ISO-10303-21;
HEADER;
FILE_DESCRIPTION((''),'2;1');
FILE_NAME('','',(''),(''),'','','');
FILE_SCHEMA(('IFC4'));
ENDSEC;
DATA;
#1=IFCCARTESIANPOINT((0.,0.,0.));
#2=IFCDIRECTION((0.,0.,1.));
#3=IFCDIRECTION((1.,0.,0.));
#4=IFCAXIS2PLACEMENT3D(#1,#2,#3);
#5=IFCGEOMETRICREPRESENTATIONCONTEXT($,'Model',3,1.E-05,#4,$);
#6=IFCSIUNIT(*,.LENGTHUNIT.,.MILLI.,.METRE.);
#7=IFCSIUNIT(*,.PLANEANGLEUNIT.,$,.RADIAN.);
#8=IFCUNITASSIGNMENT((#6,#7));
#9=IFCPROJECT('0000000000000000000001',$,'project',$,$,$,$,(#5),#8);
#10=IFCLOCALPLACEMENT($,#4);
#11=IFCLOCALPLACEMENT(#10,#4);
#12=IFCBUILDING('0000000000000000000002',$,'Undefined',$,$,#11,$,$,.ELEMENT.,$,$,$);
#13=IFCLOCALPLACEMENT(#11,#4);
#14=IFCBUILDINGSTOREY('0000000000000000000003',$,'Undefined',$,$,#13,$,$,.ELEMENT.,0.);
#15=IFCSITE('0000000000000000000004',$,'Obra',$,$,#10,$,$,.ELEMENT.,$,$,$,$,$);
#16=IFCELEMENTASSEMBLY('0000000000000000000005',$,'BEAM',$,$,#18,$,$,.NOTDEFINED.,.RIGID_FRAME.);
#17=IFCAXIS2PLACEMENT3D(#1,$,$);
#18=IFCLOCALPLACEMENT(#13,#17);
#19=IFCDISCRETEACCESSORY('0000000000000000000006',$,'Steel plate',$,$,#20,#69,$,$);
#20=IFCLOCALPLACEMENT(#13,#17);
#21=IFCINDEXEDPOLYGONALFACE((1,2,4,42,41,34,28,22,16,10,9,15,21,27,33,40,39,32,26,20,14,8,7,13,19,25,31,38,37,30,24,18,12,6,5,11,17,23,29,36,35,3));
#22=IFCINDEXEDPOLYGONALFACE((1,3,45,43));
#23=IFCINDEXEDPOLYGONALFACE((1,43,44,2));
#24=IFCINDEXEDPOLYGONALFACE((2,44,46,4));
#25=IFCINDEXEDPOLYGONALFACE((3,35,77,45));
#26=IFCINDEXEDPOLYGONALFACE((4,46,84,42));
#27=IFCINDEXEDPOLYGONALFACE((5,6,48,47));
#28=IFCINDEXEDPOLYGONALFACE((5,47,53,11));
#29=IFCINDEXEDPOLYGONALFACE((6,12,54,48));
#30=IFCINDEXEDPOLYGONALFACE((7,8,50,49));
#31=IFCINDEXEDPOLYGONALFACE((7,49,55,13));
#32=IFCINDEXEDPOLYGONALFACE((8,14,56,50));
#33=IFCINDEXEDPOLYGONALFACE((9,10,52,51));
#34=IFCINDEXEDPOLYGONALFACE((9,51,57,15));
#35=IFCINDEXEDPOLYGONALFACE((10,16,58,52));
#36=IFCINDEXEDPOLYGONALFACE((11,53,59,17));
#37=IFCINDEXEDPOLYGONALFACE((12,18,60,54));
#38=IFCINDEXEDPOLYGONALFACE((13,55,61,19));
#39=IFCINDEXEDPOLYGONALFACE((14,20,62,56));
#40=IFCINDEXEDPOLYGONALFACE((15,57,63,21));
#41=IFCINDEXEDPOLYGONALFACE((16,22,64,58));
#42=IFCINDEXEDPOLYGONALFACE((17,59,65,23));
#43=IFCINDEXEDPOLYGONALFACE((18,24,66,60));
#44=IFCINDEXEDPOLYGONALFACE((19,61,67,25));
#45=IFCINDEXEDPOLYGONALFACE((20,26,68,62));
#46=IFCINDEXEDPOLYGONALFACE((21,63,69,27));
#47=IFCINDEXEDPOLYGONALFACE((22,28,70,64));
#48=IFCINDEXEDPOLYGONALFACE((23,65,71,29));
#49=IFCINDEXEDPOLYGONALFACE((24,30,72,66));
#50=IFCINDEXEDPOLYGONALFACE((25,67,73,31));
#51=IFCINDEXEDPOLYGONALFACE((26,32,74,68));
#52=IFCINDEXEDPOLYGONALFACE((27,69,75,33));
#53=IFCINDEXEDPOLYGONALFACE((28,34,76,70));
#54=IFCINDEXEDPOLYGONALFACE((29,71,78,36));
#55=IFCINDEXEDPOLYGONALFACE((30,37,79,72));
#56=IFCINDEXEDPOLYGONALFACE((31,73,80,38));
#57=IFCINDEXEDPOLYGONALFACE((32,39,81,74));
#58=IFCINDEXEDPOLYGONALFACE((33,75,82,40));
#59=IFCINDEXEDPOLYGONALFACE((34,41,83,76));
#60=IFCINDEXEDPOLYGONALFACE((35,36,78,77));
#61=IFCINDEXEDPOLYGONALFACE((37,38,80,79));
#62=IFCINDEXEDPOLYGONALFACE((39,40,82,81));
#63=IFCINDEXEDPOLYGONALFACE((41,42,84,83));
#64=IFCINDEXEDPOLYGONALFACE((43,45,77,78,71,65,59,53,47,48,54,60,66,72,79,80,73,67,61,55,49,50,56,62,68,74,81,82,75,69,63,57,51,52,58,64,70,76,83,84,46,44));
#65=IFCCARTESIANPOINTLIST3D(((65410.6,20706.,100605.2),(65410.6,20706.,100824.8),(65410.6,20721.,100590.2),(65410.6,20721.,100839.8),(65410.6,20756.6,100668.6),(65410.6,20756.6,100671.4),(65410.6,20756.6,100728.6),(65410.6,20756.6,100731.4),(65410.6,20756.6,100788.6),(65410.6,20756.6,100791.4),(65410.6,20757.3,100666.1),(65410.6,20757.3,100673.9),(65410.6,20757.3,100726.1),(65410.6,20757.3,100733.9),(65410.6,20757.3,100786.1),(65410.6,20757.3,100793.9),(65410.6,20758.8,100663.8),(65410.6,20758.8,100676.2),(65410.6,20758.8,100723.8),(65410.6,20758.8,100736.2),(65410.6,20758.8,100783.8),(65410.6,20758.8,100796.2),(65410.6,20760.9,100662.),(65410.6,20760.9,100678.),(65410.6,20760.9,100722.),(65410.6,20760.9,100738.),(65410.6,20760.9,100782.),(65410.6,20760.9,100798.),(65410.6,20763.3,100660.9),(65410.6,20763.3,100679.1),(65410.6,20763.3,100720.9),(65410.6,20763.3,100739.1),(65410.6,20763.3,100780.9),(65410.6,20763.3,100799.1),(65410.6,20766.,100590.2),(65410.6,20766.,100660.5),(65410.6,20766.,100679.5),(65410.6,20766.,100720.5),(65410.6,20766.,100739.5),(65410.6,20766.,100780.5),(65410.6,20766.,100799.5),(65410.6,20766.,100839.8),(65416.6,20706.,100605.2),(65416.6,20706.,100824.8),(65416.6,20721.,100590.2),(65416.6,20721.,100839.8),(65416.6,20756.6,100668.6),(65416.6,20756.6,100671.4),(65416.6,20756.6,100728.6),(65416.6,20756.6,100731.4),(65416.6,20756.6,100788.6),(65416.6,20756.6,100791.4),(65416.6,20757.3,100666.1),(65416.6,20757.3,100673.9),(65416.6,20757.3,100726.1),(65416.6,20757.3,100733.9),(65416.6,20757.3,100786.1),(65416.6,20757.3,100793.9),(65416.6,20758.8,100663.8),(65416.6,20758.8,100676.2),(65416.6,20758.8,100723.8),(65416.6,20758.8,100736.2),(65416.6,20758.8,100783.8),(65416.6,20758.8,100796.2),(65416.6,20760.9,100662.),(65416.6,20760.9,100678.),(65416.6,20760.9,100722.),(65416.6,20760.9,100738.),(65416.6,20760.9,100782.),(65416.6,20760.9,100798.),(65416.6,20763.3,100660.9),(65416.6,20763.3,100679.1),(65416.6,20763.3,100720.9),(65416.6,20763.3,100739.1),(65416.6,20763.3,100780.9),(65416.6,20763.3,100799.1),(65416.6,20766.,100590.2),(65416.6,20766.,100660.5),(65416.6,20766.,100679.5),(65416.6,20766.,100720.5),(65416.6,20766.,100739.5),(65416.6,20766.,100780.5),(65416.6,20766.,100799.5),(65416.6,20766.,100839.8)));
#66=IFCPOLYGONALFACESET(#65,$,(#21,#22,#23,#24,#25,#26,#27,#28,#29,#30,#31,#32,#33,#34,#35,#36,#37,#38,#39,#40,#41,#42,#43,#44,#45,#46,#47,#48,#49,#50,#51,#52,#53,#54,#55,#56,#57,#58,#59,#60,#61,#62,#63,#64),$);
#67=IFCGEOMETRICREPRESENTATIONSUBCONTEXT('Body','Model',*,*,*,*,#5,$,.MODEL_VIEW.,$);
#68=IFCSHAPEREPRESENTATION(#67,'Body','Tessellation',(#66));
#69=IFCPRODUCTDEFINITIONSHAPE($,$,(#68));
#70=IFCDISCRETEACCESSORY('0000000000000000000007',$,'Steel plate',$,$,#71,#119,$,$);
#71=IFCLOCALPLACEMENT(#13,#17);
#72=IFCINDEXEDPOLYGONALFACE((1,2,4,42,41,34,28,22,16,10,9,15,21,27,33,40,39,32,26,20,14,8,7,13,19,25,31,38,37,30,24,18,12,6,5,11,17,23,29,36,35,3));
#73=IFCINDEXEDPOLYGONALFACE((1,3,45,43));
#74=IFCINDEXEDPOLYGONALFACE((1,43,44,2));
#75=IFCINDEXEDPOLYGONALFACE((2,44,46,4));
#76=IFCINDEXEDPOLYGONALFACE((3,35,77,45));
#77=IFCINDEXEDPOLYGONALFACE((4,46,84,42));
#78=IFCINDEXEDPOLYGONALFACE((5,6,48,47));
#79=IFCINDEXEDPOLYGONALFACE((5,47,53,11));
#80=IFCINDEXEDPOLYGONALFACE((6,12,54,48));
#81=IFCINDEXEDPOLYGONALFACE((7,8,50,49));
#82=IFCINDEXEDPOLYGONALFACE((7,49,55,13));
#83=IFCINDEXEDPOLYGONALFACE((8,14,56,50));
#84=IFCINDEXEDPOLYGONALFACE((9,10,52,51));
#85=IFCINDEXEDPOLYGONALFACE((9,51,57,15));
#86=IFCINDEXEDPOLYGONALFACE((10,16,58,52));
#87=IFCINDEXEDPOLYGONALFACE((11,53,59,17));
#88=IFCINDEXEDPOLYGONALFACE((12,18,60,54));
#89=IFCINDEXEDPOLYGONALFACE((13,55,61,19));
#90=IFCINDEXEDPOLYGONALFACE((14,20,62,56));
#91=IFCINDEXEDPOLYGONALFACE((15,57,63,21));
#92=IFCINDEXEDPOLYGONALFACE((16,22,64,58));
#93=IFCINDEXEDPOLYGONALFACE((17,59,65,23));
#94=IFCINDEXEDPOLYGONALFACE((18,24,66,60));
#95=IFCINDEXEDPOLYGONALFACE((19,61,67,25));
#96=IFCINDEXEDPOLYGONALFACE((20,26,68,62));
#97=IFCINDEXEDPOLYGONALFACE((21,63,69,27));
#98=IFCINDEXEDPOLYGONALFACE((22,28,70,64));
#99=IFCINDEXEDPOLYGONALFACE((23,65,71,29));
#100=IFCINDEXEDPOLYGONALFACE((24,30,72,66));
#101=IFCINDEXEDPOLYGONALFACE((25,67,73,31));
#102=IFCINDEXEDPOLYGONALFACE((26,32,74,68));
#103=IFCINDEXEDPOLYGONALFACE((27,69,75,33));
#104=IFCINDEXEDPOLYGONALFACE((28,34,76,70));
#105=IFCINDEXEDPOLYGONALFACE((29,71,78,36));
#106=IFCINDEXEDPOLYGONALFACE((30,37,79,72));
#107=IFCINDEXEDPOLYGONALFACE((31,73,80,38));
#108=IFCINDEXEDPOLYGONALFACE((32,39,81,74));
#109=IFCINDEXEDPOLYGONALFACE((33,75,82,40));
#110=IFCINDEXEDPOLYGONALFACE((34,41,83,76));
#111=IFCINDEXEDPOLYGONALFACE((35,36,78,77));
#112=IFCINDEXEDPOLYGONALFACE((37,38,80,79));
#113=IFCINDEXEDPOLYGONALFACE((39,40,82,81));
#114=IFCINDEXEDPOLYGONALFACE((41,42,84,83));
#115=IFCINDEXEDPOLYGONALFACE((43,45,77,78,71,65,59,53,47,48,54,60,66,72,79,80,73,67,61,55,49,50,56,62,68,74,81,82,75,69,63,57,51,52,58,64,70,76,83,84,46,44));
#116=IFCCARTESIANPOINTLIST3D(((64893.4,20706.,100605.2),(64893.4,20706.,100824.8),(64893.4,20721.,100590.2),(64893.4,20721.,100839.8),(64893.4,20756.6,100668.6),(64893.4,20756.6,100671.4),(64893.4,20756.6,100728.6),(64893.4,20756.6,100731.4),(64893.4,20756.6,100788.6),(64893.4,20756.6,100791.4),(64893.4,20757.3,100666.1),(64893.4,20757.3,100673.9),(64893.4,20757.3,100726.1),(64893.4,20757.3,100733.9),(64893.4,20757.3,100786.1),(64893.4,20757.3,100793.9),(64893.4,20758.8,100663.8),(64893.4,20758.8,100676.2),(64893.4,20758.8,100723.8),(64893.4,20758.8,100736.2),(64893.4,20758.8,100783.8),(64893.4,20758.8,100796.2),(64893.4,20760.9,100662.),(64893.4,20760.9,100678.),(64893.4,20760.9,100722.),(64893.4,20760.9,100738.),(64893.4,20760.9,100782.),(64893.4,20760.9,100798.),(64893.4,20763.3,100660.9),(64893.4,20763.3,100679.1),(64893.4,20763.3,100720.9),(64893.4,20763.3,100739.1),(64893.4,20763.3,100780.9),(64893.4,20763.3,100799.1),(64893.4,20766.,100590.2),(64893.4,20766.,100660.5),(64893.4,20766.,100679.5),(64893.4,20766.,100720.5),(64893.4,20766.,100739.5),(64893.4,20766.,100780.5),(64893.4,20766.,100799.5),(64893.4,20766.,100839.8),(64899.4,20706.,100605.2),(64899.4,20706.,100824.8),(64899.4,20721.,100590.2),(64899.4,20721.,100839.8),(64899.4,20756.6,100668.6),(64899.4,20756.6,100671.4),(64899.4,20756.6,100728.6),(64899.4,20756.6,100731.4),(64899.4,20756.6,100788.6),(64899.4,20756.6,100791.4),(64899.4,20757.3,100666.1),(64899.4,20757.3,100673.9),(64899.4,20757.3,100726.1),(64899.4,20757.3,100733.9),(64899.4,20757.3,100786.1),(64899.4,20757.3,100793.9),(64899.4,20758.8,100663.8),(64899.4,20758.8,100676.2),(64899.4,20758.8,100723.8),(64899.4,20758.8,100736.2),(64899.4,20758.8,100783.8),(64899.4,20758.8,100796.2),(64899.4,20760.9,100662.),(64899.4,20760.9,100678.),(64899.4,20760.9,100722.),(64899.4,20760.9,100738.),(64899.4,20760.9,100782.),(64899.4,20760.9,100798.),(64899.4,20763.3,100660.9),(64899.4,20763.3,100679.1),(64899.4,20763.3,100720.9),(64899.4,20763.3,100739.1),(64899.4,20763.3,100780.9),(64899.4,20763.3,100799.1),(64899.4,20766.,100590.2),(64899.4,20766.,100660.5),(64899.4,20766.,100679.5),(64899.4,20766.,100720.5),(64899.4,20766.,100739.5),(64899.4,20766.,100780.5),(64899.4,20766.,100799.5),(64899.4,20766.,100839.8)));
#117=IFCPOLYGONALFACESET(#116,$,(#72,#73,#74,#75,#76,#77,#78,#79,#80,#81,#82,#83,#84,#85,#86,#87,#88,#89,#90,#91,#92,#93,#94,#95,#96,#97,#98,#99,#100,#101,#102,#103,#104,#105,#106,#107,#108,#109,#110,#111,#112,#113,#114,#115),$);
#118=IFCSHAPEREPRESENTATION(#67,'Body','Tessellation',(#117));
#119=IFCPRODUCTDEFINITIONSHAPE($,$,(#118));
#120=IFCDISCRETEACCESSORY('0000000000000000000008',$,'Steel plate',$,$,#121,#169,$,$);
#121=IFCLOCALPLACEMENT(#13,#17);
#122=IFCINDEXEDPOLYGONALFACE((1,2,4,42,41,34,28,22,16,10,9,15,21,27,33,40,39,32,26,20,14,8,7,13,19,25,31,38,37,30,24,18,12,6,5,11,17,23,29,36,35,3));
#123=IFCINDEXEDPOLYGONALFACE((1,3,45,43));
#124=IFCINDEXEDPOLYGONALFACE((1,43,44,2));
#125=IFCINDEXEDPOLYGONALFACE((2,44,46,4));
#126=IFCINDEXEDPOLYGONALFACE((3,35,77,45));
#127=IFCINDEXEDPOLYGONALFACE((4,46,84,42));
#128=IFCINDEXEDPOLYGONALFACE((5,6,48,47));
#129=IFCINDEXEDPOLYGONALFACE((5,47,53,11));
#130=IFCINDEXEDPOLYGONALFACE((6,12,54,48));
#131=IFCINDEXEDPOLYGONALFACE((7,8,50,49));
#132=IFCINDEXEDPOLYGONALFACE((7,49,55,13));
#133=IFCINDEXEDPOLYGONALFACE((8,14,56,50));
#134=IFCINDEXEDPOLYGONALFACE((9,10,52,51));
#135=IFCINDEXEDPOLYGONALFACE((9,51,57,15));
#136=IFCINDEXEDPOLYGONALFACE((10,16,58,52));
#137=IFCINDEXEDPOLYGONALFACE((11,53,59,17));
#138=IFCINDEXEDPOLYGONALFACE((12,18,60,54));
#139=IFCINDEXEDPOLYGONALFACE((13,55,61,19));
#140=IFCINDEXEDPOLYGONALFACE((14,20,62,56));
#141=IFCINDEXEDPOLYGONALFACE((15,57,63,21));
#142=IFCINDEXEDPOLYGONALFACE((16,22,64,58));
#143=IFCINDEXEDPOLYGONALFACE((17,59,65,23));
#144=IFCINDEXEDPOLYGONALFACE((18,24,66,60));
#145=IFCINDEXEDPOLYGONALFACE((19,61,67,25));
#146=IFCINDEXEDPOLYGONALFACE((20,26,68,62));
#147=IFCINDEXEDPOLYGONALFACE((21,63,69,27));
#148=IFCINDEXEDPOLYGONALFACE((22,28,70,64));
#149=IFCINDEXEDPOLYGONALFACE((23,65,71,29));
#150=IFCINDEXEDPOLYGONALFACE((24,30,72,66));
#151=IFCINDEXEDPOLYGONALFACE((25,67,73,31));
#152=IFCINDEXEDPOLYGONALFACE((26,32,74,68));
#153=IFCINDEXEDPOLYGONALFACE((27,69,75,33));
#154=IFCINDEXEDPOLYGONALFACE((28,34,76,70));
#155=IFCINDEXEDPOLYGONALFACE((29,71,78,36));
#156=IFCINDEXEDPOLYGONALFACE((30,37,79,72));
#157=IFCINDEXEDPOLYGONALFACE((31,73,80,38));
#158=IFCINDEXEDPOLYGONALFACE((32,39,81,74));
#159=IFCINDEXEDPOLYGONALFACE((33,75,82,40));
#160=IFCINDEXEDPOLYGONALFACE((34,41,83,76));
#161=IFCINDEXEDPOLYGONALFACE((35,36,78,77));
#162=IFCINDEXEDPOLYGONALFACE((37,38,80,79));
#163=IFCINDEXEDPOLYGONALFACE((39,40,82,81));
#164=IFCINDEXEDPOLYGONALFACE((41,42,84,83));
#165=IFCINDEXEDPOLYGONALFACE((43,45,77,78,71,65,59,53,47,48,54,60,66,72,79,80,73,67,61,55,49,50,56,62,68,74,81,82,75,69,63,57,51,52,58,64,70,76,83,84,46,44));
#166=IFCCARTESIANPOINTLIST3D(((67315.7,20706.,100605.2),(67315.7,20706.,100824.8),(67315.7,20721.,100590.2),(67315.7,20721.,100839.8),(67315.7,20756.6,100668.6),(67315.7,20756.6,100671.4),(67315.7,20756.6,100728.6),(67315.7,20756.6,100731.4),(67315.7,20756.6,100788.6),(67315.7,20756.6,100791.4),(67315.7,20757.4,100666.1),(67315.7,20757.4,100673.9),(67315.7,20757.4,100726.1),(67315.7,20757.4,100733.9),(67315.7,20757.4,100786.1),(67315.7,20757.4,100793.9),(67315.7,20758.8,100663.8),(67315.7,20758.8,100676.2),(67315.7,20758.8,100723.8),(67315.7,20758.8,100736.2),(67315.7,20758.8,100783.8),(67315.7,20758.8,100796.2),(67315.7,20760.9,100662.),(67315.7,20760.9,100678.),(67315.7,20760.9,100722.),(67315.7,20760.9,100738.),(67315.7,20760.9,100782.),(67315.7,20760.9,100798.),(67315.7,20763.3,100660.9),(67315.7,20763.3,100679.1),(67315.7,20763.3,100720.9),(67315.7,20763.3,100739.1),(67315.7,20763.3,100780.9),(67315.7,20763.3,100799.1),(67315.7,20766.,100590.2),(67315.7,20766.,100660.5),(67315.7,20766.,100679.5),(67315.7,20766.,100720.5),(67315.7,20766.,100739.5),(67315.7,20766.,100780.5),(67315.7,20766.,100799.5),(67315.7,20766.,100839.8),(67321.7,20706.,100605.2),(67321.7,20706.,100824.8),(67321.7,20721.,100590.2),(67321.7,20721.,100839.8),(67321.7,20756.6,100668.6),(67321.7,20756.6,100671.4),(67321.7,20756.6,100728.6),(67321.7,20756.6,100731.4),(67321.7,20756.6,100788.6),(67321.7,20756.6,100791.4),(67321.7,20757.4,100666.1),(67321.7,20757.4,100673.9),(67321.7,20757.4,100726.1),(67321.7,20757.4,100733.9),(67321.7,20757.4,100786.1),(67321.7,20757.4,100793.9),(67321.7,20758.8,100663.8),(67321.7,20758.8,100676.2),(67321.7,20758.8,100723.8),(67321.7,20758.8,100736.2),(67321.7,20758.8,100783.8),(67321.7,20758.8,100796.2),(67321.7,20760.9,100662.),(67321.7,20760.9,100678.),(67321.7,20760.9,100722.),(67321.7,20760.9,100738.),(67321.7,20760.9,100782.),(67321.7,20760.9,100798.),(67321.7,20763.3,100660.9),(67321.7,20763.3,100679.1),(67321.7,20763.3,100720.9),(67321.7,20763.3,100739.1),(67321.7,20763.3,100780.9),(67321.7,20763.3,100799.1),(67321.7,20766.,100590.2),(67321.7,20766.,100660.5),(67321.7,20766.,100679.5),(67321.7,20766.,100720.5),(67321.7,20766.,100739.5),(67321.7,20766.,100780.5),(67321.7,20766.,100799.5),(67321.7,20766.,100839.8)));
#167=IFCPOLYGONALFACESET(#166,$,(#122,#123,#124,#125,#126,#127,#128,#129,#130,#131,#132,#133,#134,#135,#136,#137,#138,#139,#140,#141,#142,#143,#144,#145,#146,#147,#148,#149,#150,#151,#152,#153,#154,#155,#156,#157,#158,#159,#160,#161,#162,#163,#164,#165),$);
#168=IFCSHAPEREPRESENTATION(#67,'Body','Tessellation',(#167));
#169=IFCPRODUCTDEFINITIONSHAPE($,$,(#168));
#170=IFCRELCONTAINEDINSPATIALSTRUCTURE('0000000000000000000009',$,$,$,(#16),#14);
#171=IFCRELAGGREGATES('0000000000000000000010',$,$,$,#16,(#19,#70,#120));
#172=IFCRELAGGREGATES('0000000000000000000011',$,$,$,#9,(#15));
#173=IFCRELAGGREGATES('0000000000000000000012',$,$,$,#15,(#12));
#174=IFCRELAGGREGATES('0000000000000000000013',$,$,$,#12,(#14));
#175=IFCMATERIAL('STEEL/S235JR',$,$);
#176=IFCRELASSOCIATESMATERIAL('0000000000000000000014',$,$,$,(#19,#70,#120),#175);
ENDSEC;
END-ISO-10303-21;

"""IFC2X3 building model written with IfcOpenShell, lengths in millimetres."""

from ifc_helpers import new_model, si_unit, frame, origin_with_axes, origin_2d_with_axis, place, context, subcontext, project, spatial, polyline, circle, outline, extrude, source, transform, mapped, material, element, aggregate, save


model = new_model("IFC2X3")

# Units and contexts
model_context = context("Model", 3, precision=1e-05, world=origin_with_axes())
body_context = subcontext(model_context, "Body", "Model", "MODEL_VIEW")
ifc_project = project(units=[si_unit("LENGTHUNIT", "METRE", prefix="MILLI"), si_unit("PLANEANGLEUNIT", "RADIAN")], contexts=[model_context])

# Site, building, storey
site_placement = place(None, origin_with_axes())
site = spatial("IfcSite", under=ifc_project, at=site_placement, Name="Obra", CompositionType="ELEMENT")
building_placement = place(site_placement, origin_with_axes())
building = spatial("IfcBuilding", under=site, at=building_placement, Name="Undefined", CompositionType="ELEMENT")
storey_placement = place(building_placement, origin_with_axes())
storey = spatial("IfcBuildingStorey", under=building, at=storey_placement, Name="Undefined", CompositionType="ELEMENT", Elevation=0.0)

# Shared definitions
ifc_material = material(Name="STEEL/S235JR")

# Element assembly, discrete accessories, openings
assembly_1_placement = place(storey_placement, origin_with_axes())
assembly_1 = element("IfcElementAssembly", 1, at=assembly_1_placement, inside=storey, Name="BEAM", AssemblyPlace="NOTDEFINED", PredefinedType="RIGID_FRAME")
shared_shape_1 = source(origin_with_axes(), body_context, "Body", "SweptSolid", [
    extrude(circle(Radius=9.5, at=origin_2d_with_axis()), frame((0.0, -9.2, 0.0), z_axis=(0.0, 1.0, 0.0), x_axis=(1.0, 0.0, 0.0)), (0.0, 0.0, 1.0), 6.2),
])
discrete_accessory_1_placement = place(assembly_1_placement, frame((65413.6, 20766.0, 100590.2), z_axis=(-1.0, -0.000002, 0.0), x_axis=(0.000002, -1.0, 0.0)))
discrete_accessory_1 = element("IfcDiscreteAccessory", 2, at=discrete_accessory_1_placement, material=ifc_material, Name="Steel plate", context=body_context, shape_type="SweptSolid", body=[
    extrude(outline(polyline([(0.0, 0.0), (45.0, 0.0), (60.0, 15.0), (60.0, 234.6), (45.0, 249.6), (0.0, 249.6), (0.0, 0.0)])), frame((0.0, 0.0, -3.0), z_axis=(0.0, 0.0, 1.0), x_axis=(1.0, 0.0, 0.0)), (0.0, 0.0, 1.0), 6.0),
])
opening_1_placement = place(assembly_1_placement, frame((65407.5, 20716.0, 100850.0), z_axis=(-0.000002, 1.0, 0.0), x_axis=(0.0, 0.0, -1.0)))
element("IfcOpeningElement", 3, at=opening_1_placement, cuts=discrete_accessory_1, ObjectType="Opening", context=body_context, shape_type="MappedRepresentation", body=[
    mapped(shared_shape_1, transform((60.0, 0.0, 50.0))),
    mapped(shared_shape_1, transform((120.0, 0.0, 50.0))),
    mapped(shared_shape_1, transform((180.0, 0.0, 50.0))),
])
discrete_accessory_2_placement = place(assembly_1_placement, frame((64896.4, 20766.0, 100590.2), z_axis=(-1.0, -0.000002, 0.0), x_axis=(0.000002, -1.0, 0.0)))
discrete_accessory_2 = element("IfcDiscreteAccessory", 4, at=discrete_accessory_2_placement, material=ifc_material, Name="Steel plate", context=body_context, shape_type="SweptSolid", body=[
    extrude(outline(polyline([(0.0, 0.0), (45.0, 0.0), (60.0, 15.0), (60.0, 234.6), (45.0, 249.6), (0.0, 249.6), (0.0, 0.0)])), frame((0.0, 0.0, -3.0), z_axis=(0.0, 0.0, 1.0), x_axis=(1.0, 0.0, 0.0)), (0.0, 0.0, 1.0), 6.0),
])
opening_2_placement = place(assembly_1_placement, frame((64890.3, 20716.0, 100850.0), z_axis=(-0.000002, 1.0, 0.0), x_axis=(0.0, 0.0, -1.0)))
element("IfcOpeningElement", 5, at=opening_2_placement, cuts=discrete_accessory_2, ObjectType="Opening", context=body_context, shape_type="MappedRepresentation", body=[
    mapped(shared_shape_1, transform((60.0, 0.0, 50.0))),
    mapped(shared_shape_1, transform((120.0, 0.0, 50.0))),
    mapped(shared_shape_1, transform((180.0, 0.0, 50.0))),
])
discrete_accessory_3_placement = place(assembly_1_placement, frame((67318.7, 20766.0, 100590.2), z_axis=(-1.0, -0.000002, 0.0), x_axis=(0.000002, -1.0, 0.0)))
discrete_accessory_3 = element("IfcDiscreteAccessory", 6, at=discrete_accessory_3_placement, material=ifc_material, Name="Steel plate", context=body_context, shape_type="SweptSolid", body=[
    extrude(outline(polyline([(0.0, 0.0), (45.0, 0.0), (60.0, 15.0), (60.0, 234.6), (45.0, 249.6), (0.0, 249.6), (0.0, 0.0)])), frame((0.0, 0.0, -3.0), z_axis=(0.0, 0.0, 1.0), x_axis=(1.0, 0.0, 0.0)), (0.0, 0.0, 1.0), 6.0),
])
opening_3_placement = place(assembly_1_placement, frame((67312.6, 20716.0, 100850.0), z_axis=(-0.000002, 1.0, 0.0), x_axis=(0.0, 0.0, -1.0)))
element("IfcOpeningElement", 7, at=opening_3_placement, cuts=discrete_accessory_3, ObjectType="Opening", context=body_context, shape_type="MappedRepresentation", body=[
    mapped(shared_shape_1, transform((60.0, 0.0, 50.0))),
    mapped(shared_shape_1, transform((120.0, 0.0, 50.0))),
    mapped(shared_shape_1, transform((180.0, 0.0, 50.0))),
])
aggregate(assembly_1, [discrete_accessory_1, discrete_accessory_2, discrete_accessory_3])

save(model, "model.ifc")
